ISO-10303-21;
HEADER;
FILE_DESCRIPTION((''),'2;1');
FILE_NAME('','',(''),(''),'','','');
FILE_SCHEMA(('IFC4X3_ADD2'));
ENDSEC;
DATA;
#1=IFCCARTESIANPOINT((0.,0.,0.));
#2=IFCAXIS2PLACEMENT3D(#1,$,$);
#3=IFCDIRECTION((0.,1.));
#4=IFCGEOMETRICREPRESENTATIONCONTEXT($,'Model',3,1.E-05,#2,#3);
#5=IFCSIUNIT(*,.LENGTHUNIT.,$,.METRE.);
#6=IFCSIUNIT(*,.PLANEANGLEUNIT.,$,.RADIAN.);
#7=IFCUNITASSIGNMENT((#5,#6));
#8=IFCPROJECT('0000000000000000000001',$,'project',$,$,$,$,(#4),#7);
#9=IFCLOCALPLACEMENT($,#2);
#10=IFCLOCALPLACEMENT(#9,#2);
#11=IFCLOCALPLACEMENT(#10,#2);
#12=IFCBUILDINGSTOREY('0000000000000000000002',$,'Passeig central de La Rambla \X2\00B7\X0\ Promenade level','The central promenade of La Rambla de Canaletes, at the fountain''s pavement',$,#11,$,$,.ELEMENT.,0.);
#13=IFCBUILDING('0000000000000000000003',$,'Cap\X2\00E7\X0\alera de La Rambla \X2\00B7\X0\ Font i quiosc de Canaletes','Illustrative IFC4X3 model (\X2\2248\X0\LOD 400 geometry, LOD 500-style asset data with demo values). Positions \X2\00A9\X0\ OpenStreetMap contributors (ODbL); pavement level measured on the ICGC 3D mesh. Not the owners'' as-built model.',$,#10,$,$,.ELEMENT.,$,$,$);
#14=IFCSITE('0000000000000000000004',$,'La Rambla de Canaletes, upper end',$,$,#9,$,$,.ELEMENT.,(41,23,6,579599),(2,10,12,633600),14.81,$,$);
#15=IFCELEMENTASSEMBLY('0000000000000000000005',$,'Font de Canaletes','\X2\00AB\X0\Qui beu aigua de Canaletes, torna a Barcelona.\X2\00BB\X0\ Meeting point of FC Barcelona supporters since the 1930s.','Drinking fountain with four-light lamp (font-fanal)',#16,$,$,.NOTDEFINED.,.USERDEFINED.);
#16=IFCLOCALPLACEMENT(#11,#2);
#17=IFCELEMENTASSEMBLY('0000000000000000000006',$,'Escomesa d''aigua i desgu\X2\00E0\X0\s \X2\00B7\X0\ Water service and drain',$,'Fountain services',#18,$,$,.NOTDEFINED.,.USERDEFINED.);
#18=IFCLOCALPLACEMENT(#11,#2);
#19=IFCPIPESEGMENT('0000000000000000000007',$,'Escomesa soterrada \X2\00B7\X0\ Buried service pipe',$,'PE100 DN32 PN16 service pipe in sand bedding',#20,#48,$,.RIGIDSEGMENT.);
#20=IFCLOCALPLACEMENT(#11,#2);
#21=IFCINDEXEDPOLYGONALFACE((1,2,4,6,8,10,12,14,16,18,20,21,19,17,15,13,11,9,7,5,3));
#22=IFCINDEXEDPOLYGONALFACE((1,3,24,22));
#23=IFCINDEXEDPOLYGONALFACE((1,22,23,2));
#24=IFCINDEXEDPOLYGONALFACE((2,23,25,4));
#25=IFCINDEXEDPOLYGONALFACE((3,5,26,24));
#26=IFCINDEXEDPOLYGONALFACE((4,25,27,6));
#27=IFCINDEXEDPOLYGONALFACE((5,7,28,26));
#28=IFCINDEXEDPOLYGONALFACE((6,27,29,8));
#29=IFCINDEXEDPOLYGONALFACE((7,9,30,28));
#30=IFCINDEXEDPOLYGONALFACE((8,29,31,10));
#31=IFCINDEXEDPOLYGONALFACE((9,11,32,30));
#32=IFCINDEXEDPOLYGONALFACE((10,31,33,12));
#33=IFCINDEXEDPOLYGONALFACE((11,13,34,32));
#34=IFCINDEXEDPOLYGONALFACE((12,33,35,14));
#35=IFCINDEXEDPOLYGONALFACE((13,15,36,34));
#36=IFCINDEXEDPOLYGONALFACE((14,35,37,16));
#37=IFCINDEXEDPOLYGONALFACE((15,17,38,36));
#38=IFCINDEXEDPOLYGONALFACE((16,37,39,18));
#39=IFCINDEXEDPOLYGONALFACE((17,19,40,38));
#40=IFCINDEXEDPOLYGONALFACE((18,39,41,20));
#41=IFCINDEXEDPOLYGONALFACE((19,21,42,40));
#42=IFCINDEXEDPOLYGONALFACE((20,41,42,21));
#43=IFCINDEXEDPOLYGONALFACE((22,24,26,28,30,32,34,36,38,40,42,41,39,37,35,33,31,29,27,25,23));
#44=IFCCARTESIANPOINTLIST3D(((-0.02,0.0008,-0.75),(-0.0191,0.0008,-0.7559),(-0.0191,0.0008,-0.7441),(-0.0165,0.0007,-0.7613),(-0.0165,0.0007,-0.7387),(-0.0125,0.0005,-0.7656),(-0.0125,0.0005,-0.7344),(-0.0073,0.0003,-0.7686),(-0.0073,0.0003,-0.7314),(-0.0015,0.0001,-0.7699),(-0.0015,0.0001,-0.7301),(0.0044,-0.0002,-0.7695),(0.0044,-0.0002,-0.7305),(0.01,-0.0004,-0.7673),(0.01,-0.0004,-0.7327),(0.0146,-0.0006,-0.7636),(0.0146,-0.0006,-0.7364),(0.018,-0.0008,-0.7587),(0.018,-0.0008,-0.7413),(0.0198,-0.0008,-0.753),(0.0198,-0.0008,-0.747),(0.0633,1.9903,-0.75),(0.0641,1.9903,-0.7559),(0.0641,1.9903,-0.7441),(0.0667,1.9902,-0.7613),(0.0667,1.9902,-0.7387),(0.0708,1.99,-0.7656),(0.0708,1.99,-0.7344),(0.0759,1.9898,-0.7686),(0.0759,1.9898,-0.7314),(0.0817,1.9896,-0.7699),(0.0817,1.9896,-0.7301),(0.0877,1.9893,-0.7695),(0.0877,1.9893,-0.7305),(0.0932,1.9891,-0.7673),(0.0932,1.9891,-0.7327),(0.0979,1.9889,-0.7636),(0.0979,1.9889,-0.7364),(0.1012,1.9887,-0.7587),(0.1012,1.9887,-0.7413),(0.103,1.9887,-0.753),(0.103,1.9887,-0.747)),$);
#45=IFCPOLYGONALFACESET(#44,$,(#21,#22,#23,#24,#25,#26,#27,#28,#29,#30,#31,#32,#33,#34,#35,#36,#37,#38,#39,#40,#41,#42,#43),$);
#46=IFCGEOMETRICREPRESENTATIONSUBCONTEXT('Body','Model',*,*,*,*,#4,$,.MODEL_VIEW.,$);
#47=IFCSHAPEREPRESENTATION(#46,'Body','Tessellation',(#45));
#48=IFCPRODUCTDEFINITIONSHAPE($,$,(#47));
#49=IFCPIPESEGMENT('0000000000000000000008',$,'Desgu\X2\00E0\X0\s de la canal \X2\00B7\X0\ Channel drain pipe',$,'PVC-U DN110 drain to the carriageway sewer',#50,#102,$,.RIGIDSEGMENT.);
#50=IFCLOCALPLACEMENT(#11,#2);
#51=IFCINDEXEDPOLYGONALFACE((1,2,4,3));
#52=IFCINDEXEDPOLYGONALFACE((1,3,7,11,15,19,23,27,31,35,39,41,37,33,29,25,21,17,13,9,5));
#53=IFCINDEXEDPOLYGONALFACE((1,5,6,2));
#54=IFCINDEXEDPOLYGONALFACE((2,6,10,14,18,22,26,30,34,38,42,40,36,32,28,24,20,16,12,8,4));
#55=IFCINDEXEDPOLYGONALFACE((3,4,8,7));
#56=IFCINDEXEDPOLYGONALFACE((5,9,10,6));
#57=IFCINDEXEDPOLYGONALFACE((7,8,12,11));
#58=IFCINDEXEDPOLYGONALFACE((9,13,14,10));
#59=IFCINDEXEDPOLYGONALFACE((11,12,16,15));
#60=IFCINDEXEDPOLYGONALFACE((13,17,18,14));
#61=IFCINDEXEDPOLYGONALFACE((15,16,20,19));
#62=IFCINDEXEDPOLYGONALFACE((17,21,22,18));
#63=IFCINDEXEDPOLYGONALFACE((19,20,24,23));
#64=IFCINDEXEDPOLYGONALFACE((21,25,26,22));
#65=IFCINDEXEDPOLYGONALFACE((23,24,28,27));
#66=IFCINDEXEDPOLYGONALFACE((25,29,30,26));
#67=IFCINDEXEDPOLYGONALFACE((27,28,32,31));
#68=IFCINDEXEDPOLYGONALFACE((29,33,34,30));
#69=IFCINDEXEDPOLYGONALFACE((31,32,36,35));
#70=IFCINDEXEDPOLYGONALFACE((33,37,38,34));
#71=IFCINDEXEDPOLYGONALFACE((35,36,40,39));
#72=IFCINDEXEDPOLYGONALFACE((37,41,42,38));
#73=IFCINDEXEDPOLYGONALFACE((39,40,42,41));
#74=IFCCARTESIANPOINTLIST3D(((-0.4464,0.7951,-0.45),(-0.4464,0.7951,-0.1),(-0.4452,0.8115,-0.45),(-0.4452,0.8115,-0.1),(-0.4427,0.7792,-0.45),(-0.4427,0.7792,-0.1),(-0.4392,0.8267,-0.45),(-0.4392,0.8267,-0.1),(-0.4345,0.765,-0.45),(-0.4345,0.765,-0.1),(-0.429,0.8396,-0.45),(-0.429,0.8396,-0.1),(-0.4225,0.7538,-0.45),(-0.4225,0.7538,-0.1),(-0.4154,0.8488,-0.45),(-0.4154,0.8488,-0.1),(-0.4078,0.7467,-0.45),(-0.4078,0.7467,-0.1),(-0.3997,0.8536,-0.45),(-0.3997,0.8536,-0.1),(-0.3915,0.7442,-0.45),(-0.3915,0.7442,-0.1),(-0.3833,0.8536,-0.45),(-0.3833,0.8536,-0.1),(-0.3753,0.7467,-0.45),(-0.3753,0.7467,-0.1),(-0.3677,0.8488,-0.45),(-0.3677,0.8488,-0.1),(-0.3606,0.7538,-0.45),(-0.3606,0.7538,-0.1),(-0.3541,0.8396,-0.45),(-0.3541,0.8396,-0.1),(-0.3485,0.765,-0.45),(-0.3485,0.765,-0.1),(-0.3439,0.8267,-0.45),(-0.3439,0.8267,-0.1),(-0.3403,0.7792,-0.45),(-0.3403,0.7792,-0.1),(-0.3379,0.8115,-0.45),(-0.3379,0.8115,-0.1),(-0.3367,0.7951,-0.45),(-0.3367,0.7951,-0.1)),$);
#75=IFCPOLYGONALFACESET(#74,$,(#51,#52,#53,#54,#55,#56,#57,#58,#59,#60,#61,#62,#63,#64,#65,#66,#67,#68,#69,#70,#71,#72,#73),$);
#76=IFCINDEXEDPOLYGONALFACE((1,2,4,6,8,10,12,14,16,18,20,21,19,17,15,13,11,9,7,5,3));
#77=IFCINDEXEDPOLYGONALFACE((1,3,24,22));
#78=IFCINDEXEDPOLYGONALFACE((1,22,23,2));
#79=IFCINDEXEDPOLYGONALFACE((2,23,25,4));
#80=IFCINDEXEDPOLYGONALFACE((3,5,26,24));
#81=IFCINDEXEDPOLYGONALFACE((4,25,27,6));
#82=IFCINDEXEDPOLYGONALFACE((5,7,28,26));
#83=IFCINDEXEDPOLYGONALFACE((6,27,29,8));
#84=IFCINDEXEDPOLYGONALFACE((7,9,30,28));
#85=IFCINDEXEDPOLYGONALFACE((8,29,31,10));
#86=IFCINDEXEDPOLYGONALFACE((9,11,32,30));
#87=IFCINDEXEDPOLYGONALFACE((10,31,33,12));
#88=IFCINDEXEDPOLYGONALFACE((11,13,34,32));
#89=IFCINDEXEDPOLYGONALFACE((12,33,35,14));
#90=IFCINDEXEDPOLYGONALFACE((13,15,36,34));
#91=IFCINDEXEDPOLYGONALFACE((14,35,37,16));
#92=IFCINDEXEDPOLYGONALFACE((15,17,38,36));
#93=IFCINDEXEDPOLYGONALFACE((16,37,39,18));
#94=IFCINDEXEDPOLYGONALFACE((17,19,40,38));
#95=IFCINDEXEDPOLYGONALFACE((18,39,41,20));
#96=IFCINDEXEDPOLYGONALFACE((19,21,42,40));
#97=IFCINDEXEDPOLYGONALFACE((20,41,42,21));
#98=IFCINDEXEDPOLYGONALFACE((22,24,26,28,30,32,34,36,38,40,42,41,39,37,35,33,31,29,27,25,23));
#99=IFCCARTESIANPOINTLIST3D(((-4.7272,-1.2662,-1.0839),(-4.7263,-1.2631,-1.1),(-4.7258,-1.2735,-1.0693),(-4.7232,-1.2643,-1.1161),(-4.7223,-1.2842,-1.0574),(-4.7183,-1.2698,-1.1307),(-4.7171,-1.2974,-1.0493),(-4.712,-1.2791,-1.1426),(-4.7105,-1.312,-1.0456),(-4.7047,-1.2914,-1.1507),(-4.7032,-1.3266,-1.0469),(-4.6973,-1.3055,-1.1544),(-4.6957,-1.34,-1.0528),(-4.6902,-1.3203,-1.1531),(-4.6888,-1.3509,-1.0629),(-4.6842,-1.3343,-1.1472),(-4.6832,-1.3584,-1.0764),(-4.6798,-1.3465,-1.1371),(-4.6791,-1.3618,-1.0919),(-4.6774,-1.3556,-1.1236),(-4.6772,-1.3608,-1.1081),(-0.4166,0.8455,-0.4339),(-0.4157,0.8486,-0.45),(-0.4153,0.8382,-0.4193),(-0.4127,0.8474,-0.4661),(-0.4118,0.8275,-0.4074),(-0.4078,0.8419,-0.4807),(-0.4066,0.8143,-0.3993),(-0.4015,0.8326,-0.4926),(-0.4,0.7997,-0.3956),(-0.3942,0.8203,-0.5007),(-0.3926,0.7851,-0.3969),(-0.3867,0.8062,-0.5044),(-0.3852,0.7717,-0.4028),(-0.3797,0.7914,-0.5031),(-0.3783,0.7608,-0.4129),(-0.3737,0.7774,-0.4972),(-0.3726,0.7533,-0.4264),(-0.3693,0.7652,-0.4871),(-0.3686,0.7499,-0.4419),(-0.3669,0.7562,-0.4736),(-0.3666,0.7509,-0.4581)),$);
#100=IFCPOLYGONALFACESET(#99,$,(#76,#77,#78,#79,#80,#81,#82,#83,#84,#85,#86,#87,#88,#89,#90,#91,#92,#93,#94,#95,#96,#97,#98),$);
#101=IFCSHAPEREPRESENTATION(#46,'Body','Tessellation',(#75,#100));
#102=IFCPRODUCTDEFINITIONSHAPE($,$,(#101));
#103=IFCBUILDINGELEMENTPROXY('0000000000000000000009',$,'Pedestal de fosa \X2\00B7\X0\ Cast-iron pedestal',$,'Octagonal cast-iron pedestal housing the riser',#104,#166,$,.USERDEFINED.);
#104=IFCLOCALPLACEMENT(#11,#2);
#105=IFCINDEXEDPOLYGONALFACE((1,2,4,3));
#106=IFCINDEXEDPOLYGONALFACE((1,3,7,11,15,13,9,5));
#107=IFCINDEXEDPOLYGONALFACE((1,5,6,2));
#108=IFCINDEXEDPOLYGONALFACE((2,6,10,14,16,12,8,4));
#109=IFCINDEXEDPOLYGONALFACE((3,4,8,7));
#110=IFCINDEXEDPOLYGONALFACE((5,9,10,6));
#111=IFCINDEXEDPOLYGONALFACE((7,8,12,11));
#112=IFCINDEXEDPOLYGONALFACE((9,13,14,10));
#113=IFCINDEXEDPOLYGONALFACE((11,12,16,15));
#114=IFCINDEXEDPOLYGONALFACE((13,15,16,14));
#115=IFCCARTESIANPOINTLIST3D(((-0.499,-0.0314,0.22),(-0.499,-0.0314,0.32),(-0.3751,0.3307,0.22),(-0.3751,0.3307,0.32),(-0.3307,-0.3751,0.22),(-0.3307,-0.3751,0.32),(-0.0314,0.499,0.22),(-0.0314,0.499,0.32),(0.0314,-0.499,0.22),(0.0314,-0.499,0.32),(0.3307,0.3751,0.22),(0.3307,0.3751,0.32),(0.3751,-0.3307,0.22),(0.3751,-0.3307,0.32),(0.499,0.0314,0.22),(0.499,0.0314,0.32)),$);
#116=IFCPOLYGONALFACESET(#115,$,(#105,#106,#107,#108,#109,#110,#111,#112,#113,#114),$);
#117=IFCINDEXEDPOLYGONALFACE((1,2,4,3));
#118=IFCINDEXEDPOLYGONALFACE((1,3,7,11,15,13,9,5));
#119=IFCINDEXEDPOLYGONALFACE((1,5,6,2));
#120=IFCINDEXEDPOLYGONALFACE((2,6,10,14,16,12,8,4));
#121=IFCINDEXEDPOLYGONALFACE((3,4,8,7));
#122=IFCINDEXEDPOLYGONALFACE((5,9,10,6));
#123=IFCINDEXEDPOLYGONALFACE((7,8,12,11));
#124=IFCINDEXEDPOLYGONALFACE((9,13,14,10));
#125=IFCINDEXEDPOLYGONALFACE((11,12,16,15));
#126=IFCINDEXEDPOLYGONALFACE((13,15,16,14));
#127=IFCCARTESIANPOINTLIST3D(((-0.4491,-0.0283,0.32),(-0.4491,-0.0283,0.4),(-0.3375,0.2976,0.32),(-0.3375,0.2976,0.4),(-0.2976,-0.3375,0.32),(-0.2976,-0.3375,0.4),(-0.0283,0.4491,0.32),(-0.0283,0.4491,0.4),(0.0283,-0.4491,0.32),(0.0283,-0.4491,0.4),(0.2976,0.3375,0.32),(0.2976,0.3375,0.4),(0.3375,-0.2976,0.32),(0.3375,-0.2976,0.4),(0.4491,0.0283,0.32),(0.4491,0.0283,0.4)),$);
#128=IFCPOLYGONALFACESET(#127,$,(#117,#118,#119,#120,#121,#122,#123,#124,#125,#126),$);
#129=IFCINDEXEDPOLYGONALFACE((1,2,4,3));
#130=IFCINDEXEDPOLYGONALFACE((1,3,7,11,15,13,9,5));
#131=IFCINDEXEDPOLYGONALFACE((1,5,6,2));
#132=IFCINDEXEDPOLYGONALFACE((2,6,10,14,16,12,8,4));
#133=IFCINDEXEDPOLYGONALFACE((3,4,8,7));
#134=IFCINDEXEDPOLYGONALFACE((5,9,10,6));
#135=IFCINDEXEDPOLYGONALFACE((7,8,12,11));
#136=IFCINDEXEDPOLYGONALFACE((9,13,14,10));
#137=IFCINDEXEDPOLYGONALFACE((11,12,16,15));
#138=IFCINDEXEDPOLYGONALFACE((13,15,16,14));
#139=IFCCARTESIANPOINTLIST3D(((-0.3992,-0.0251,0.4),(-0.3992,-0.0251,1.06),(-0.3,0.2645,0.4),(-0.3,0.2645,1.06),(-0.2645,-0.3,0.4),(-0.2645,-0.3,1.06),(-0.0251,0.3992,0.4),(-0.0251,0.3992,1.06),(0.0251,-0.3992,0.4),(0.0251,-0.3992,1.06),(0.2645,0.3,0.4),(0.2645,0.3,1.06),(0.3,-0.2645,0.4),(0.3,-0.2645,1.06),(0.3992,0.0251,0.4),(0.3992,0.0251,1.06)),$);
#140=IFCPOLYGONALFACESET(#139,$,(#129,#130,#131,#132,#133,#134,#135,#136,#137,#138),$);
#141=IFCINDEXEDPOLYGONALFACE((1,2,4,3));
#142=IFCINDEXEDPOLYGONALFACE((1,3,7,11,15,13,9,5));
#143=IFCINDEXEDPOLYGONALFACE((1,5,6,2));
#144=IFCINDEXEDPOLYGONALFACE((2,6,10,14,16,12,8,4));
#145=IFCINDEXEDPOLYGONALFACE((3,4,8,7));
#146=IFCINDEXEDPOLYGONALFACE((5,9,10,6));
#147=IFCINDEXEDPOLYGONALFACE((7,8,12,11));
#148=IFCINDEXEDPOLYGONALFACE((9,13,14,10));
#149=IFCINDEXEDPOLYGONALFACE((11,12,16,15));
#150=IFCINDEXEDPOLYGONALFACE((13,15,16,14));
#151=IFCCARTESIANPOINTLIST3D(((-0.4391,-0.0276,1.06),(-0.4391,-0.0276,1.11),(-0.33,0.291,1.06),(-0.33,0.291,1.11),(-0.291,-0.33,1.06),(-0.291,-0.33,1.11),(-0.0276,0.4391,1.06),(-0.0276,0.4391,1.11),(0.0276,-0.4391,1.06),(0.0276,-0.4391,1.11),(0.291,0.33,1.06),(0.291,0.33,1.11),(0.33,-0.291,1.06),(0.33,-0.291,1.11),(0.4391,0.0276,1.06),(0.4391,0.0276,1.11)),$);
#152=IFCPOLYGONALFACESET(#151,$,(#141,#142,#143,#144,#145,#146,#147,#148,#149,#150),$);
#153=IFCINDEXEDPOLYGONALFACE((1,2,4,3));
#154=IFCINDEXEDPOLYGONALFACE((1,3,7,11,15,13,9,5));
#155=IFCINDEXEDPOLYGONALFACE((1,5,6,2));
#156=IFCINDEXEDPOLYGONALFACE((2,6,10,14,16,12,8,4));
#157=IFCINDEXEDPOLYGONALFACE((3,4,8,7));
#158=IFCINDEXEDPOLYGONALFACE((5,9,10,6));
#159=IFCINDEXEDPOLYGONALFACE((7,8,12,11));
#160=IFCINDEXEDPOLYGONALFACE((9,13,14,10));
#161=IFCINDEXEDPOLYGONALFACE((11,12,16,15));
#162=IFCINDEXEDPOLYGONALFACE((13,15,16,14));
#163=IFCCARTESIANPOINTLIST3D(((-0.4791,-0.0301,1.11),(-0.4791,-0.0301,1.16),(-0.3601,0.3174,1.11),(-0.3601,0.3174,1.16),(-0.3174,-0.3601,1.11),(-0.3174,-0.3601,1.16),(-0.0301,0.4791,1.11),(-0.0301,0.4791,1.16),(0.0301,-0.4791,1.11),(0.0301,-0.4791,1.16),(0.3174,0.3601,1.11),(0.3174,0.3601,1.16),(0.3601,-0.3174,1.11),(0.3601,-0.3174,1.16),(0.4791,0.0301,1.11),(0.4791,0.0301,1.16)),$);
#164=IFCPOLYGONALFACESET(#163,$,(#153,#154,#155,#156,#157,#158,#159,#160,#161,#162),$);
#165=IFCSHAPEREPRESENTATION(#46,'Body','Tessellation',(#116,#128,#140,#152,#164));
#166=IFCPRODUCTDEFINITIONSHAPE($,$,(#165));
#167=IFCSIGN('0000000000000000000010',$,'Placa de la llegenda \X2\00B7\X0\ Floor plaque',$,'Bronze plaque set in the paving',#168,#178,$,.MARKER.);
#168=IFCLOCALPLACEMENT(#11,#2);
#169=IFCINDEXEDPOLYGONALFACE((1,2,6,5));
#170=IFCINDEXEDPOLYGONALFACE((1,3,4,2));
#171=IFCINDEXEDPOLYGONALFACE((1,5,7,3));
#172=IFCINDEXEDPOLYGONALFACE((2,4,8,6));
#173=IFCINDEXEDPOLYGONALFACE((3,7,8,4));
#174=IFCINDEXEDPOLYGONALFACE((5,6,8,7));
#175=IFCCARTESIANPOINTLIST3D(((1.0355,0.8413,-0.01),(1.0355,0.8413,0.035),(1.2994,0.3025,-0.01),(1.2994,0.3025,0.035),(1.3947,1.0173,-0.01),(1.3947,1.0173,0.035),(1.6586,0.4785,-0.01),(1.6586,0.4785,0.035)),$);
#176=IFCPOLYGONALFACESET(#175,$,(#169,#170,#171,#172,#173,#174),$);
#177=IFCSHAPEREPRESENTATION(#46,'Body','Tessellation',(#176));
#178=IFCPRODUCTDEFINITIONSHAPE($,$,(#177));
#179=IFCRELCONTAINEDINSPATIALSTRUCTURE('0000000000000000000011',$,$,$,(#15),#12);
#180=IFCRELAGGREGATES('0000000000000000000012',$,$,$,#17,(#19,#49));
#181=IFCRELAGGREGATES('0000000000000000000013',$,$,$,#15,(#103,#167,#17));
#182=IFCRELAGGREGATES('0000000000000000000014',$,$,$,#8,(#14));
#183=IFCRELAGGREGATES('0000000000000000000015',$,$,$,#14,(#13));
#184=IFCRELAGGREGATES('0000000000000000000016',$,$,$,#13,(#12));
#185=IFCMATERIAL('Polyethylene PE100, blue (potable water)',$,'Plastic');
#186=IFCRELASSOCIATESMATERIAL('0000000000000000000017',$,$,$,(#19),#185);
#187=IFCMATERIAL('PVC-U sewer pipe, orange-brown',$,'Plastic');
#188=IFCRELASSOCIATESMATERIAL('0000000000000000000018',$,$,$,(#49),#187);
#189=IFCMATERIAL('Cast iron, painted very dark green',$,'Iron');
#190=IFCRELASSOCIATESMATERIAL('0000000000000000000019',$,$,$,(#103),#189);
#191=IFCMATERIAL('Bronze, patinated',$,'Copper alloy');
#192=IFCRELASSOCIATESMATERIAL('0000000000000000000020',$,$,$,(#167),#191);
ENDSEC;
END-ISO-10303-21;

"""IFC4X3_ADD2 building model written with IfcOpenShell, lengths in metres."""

from ifc_helpers import new_model, si_unit, direction, frame, frame_2d, origin, origin_2d_with_axis, place, context, subcontext, project, spatial, polyline, rectangle, circle, outline, extrude, material, element, aggregate, save


model = new_model("IFC4X3_ADD2")

# Units and contexts
model_context = context("Model", 3, precision=1e-05, world=origin(), true_north=direction((0.0, 1.0)))
body_context = subcontext(model_context, "Body", "Model", "MODEL_VIEW")
ifc_project = project(units=[si_unit("LENGTHUNIT", "METRE"), si_unit("PLANEANGLEUNIT", "RADIAN")], contexts=[model_context])

# Site, building, storey
site_placement = place(None, origin())
site = spatial("IfcSite", under=ifc_project, at=site_placement, Name="La Rambla de Canaletes, upper end", CompositionType="ELEMENT", RefLatitude=(41, 23, 6, 579599), RefLongitude=(2, 10, 12, 633600), RefElevation=14.81)
building_placement = place(site_placement, origin())
building = spatial("IfcBuilding", under=site, at=building_placement, Name="Capçalera de La Rambla · Font i quiosc de Canaletes", Description="Illustrative IFC4X3 model (≈LOD 400 geometry, LOD 500-style asset data with demo values). Positions © OpenStreetMap contributors (ODbL); pavement level measured on the ICGC 3D mesh. Not the owners' as-built model.", CompositionType="ELEMENT")
storey_placement = place(building_placement, origin())
storey = spatial("IfcBuildingStorey", under=building, at=storey_placement, Name="Passeig central de La Rambla · Promenade level", Description="The central promenade of La Rambla de Canaletes, at the fountain's pavement", CompositionType="ELEMENT", Elevation=0.0)

# Element assemblies, pipe segments, building element proxy, sign
assembly_1_placement = place(building_placement, origin())
assembly_1 = element("IfcElementAssembly", 1, at=assembly_1_placement, inside=storey, Name="Font de Canaletes", Description="«Qui beu aigua de Canaletes, torna a Barcelona.» Meeting point of FC Barcelona supporters since the 1930s.", ObjectType="Drinking fountain with four-light lamp (font-fanal)", AssemblyPlace="NOTDEFINED", PredefinedType="USERDEFINED")
ifc_material_1 = material(Name="Cast iron, painted very dark green", Category="Iron")
ifc_material_2 = material(Name="Bronze, patinated", Category="Copper alloy")
assembly_2_placement = place(building_placement, origin())
assembly_2 = element("IfcElementAssembly", 2, at=assembly_2_placement, Name="Escomesa d'aigua i desguàs · Water service and drain", ObjectType="Fountain services", AssemblyPlace="NOTDEFINED", PredefinedType="USERDEFINED")
ifc_material_3 = material(Name="Polyethylene PE100, blue (potable water)", Category="Plastic")
pipe_segment_1_placement = place(building_placement, origin())
pipe_segment_1 = element("IfcPipeSegment", 3, at=pipe_segment_1_placement, material=ifc_material_3, Name="Escomesa soterrada · Buried service pipe", ObjectType="PE100 DN32 PN16 service pipe in sand bedding", PredefinedType="RIGIDSEGMENT", context=body_context, shape_type="SweptSolid", body=[
    extrude(circle(Radius=0.02, at=origin_2d_with_axis()), frame((0.0832, 1.9895, -0.75), z_axis=(-0.0418, -0.999126, 0.0), x_axis=(-0.999126, 0.0418, 0.0)), (0.0, 0.0, 1.0), 1.9912),
])
ifc_material_4 = material(Name="PVC-U sewer pipe, orange-brown", Category="Plastic")
pipe_segment_2_placement = place(building_placement, origin())
pipe_segment_2 = element("IfcPipeSegment", 4, at=pipe_segment_2_placement, material=ifc_material_4, Name="Desguàs de la canal · Channel drain pipe", ObjectType="PVC-U DN110 drain to the carriageway sewer", PredefinedType="RIGIDSEGMENT", context=body_context, shape_type="SweptSolid", body=[
    extrude(circle(Radius=0.055, at=origin_2d_with_axis()), frame((-0.3915, 0.7992, -0.1), z_axis=(0.0, 0.0, -1.0), x_axis=(0.0, -1.0, 0.0)), (0.0, 0.0, 1.0), 0.35),
    extrude(circle(Radius=0.055, at=origin_2d_with_axis()), frame((-0.3915, 0.7992, -0.45), z_axis=(-0.889905, -0.43596, -0.134192), x_axis=(-0.439939, 0.898028, 0.0)), (0.0, 0.0, 1.0), 4.8438),
])
aggregate(assembly_2, [pipe_segment_1, pipe_segment_2])
proxy_placement = place(building_placement, origin())
proxy = element("IfcBuildingElementProxy", 5, at=proxy_placement, material=ifc_material_1, Name="Pedestal de fosa · Cast-iron pedestal", ObjectType="Octagonal cast-iron pedestal housing the riser", PredefinedType="USERDEFINED", context=body_context, shape_type="SweptSolid", body=[
    extrude(outline(polyline([(0.3751, -0.3307), (0.499, 0.0314), (0.3307, 0.3751), (-0.0314, 0.499), (-0.3751, 0.3307), (-0.499, -0.0314), (-0.3307, -0.3751), (0.0314, -0.499), (0.3751, -0.3307)])), frame((0.0, 0.0, 0.22)), (0.0, 0.0, 1.0), 0.1),
    extrude(outline(polyline([(0.3375, -0.2976), (0.4491, 0.0283), (0.2976, 0.3375), (-0.0283, 0.4491), (-0.3375, 0.2976), (-0.4491, -0.0283), (-0.2976, -0.3375), (0.0283, -0.4491), (0.3375, -0.2976)])), frame((0.0, 0.0, 0.32)), (0.0, 0.0, 1.0), 0.08),
    extrude(outline(polyline([(0.3, -0.2645), (0.3992, 0.0251), (0.2645, 0.3), (-0.0251, 0.3992), (-0.3, 0.2645), (-0.3992, -0.0251), (-0.2645, -0.3), (0.0251, -0.3992), (0.3, -0.2645)])), frame((0.0, 0.0, 0.4)), (0.0, 0.0, 1.0), 0.66),
    extrude(outline(polyline([(0.33, -0.291), (0.4391, 0.0276), (0.291, 0.33), (-0.0276, 0.4391), (-0.33, 0.291), (-0.4391, -0.0276), (-0.291, -0.33), (0.0276, -0.4391), (0.33, -0.291)])), frame((0.0, 0.0, 1.06)), (0.0, 0.0, 1.0), 0.05),
    extrude(outline(polyline([(0.3601, -0.3174), (0.4791, 0.0301), (0.3174, 0.3601), (-0.0301, 0.4791), (-0.3601, 0.3174), (-0.4791, -0.0301), (-0.3174, -0.3601), (0.0301, -0.4791), (0.3601, -0.3174)])), frame((0.0, 0.0, 1.11)), (0.0, 0.0, 1.0), 0.05),
])
sign_placement = place(building_placement, origin())
sign = element("IfcSign", 6, at=sign_placement, material=ifc_material_2, Name="Placa de la llegenda · Floor plaque", ObjectType="Bronze plaque set in the paving", PredefinedType="MARKER", context=body_context, shape_type="SweptSolid", body=[
    extrude(rectangle(XDim=0.6, YDim=0.4, at=frame_2d((0.0, 0.0), x_axis=(0.439939, -0.898028))), frame((1.347, 0.6599, -0.01)), (0.0, 0.0, 1.0), 0.045),
])
aggregate(assembly_1, [proxy, sign, assembly_2])

save(model, "model.ifc")
